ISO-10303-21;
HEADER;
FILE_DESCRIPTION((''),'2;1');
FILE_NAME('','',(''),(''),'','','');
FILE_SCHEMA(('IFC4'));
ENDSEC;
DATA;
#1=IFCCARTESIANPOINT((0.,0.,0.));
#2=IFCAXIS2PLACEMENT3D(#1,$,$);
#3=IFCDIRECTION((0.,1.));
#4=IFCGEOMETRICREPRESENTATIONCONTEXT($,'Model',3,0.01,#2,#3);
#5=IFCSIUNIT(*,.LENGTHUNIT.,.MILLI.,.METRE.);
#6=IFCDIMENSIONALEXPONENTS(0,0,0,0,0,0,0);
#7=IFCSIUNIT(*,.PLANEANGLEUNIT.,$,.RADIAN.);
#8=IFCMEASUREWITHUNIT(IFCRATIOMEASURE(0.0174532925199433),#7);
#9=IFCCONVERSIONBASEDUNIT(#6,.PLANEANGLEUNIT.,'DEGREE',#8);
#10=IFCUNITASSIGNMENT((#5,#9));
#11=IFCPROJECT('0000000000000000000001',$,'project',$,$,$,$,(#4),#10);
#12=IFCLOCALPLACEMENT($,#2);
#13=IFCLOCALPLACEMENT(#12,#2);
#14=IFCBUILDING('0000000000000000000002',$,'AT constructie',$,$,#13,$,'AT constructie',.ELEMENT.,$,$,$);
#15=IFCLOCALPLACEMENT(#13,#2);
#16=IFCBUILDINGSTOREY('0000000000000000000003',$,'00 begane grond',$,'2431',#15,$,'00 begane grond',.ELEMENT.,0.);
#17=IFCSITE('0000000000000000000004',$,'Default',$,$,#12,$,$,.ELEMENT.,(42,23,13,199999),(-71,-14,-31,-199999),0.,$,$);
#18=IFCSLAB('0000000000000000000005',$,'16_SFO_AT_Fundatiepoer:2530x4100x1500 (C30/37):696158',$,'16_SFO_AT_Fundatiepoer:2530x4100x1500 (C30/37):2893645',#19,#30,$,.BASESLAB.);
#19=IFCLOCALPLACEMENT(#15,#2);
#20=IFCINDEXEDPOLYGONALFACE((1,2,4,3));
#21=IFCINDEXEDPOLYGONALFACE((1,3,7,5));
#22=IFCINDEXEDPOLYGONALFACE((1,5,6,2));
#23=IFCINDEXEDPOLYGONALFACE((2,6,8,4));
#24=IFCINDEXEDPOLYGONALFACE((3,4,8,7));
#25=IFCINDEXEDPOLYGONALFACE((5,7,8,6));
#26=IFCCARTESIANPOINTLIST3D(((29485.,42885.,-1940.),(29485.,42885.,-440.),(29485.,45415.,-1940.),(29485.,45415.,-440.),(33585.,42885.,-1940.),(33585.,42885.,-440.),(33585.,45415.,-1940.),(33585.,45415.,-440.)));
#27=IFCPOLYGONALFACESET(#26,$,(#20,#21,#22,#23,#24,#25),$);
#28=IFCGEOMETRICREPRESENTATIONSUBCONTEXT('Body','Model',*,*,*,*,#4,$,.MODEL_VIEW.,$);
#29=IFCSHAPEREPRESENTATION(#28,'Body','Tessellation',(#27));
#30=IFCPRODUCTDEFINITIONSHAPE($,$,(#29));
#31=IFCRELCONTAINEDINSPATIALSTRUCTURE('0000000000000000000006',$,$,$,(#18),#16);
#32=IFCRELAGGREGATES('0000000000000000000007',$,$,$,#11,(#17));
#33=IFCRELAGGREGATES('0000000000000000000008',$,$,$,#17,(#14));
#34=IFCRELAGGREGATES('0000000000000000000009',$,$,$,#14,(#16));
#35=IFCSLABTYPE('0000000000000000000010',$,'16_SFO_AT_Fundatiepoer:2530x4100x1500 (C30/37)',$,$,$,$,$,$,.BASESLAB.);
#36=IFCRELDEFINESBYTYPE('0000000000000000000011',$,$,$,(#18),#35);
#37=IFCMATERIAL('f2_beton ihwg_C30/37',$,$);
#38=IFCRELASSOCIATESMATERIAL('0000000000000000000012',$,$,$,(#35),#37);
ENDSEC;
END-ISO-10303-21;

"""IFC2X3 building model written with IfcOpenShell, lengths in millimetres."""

from ifc_helpers import new_model, entity, si_unit, converted_unit, direction, frame, frame_2d, origin, place, context, subcontext, project, spatial, rectangle, extrude, material, type_object, element, save


model = new_model("IFC2X3")

# Units and contexts
model_context = context("Model", 3, precision=0.01, world=origin(), true_north=direction((0.0, 1.0)))
body_context = subcontext(model_context, "Body", "Model", "MODEL_VIEW")
ifc_project = project(units=[si_unit("LENGTHUNIT", "METRE", prefix="MILLI"), converted_unit("PLANEANGLEUNIT", "DEGREE", entity("IfcRatioMeasure", 0.0174532925199433), si_unit("PLANEANGLEUNIT", "RADIAN"), dimensions=[0, 0, 0, 0, 0, 0, 0])], contexts=[model_context])

# Site, building, storey
site_placement = place(None, origin())
site = spatial("IfcSite", under=ifc_project, at=site_placement, Name="Default", CompositionType="ELEMENT", RefLatitude=(42, 23, 13, 199999), RefLongitude=(-71, -14, -31, -199999), RefElevation=0.0)
building_placement = place(site_placement, origin())
building = spatial("IfcBuilding", under=site, at=building_placement, Name="AT constructie", LongName="AT constructie", CompositionType="ELEMENT")
storey_placement = place(building_placement, origin())
storey = spatial("IfcBuildingStorey", under=building, at=storey_placement, Name="00 begane grond", ObjectType="2431", LongName="00 begane grond", CompositionType="ELEMENT", Elevation=0.0)

# Shared definitions
ifc_material = material(Name="f2_beton ihwg_C30/37")

# Slab
slab_type_1 = type_object("IfcSlabType", Name="16_SFO_AT_Fundatiepoer:2530x4100x1500 (C30/37)", PredefinedType="BASESLAB", material=ifc_material)
slab_1_placement = place(storey_placement, origin())
element("IfcSlab", 1, at=slab_1_placement, inside=storey, type_object=slab_type_1, Name="16_SFO_AT_Fundatiepoer:2530x4100x1500 (C30/37):696158", ObjectType="16_SFO_AT_Fundatiepoer:2530x4100x1500 (C30/37):2893645", PredefinedType="BASESLAB", context=body_context, shape_type="SweptSolid", body=[
    extrude(rectangle(XDim=4100.0, YDim=2530.0, at=frame_2d((0.0, 0.0), x_axis=(1.0, 0.0))), frame((31535.0, 44150.0, -1940.0), z_axis=(0.0, 0.0, 1.0), x_axis=(-1.0, 0.0, 0.0)), (0.0, 0.0, 1.0), 1500.0),
])

save(model, "model.ifc")
